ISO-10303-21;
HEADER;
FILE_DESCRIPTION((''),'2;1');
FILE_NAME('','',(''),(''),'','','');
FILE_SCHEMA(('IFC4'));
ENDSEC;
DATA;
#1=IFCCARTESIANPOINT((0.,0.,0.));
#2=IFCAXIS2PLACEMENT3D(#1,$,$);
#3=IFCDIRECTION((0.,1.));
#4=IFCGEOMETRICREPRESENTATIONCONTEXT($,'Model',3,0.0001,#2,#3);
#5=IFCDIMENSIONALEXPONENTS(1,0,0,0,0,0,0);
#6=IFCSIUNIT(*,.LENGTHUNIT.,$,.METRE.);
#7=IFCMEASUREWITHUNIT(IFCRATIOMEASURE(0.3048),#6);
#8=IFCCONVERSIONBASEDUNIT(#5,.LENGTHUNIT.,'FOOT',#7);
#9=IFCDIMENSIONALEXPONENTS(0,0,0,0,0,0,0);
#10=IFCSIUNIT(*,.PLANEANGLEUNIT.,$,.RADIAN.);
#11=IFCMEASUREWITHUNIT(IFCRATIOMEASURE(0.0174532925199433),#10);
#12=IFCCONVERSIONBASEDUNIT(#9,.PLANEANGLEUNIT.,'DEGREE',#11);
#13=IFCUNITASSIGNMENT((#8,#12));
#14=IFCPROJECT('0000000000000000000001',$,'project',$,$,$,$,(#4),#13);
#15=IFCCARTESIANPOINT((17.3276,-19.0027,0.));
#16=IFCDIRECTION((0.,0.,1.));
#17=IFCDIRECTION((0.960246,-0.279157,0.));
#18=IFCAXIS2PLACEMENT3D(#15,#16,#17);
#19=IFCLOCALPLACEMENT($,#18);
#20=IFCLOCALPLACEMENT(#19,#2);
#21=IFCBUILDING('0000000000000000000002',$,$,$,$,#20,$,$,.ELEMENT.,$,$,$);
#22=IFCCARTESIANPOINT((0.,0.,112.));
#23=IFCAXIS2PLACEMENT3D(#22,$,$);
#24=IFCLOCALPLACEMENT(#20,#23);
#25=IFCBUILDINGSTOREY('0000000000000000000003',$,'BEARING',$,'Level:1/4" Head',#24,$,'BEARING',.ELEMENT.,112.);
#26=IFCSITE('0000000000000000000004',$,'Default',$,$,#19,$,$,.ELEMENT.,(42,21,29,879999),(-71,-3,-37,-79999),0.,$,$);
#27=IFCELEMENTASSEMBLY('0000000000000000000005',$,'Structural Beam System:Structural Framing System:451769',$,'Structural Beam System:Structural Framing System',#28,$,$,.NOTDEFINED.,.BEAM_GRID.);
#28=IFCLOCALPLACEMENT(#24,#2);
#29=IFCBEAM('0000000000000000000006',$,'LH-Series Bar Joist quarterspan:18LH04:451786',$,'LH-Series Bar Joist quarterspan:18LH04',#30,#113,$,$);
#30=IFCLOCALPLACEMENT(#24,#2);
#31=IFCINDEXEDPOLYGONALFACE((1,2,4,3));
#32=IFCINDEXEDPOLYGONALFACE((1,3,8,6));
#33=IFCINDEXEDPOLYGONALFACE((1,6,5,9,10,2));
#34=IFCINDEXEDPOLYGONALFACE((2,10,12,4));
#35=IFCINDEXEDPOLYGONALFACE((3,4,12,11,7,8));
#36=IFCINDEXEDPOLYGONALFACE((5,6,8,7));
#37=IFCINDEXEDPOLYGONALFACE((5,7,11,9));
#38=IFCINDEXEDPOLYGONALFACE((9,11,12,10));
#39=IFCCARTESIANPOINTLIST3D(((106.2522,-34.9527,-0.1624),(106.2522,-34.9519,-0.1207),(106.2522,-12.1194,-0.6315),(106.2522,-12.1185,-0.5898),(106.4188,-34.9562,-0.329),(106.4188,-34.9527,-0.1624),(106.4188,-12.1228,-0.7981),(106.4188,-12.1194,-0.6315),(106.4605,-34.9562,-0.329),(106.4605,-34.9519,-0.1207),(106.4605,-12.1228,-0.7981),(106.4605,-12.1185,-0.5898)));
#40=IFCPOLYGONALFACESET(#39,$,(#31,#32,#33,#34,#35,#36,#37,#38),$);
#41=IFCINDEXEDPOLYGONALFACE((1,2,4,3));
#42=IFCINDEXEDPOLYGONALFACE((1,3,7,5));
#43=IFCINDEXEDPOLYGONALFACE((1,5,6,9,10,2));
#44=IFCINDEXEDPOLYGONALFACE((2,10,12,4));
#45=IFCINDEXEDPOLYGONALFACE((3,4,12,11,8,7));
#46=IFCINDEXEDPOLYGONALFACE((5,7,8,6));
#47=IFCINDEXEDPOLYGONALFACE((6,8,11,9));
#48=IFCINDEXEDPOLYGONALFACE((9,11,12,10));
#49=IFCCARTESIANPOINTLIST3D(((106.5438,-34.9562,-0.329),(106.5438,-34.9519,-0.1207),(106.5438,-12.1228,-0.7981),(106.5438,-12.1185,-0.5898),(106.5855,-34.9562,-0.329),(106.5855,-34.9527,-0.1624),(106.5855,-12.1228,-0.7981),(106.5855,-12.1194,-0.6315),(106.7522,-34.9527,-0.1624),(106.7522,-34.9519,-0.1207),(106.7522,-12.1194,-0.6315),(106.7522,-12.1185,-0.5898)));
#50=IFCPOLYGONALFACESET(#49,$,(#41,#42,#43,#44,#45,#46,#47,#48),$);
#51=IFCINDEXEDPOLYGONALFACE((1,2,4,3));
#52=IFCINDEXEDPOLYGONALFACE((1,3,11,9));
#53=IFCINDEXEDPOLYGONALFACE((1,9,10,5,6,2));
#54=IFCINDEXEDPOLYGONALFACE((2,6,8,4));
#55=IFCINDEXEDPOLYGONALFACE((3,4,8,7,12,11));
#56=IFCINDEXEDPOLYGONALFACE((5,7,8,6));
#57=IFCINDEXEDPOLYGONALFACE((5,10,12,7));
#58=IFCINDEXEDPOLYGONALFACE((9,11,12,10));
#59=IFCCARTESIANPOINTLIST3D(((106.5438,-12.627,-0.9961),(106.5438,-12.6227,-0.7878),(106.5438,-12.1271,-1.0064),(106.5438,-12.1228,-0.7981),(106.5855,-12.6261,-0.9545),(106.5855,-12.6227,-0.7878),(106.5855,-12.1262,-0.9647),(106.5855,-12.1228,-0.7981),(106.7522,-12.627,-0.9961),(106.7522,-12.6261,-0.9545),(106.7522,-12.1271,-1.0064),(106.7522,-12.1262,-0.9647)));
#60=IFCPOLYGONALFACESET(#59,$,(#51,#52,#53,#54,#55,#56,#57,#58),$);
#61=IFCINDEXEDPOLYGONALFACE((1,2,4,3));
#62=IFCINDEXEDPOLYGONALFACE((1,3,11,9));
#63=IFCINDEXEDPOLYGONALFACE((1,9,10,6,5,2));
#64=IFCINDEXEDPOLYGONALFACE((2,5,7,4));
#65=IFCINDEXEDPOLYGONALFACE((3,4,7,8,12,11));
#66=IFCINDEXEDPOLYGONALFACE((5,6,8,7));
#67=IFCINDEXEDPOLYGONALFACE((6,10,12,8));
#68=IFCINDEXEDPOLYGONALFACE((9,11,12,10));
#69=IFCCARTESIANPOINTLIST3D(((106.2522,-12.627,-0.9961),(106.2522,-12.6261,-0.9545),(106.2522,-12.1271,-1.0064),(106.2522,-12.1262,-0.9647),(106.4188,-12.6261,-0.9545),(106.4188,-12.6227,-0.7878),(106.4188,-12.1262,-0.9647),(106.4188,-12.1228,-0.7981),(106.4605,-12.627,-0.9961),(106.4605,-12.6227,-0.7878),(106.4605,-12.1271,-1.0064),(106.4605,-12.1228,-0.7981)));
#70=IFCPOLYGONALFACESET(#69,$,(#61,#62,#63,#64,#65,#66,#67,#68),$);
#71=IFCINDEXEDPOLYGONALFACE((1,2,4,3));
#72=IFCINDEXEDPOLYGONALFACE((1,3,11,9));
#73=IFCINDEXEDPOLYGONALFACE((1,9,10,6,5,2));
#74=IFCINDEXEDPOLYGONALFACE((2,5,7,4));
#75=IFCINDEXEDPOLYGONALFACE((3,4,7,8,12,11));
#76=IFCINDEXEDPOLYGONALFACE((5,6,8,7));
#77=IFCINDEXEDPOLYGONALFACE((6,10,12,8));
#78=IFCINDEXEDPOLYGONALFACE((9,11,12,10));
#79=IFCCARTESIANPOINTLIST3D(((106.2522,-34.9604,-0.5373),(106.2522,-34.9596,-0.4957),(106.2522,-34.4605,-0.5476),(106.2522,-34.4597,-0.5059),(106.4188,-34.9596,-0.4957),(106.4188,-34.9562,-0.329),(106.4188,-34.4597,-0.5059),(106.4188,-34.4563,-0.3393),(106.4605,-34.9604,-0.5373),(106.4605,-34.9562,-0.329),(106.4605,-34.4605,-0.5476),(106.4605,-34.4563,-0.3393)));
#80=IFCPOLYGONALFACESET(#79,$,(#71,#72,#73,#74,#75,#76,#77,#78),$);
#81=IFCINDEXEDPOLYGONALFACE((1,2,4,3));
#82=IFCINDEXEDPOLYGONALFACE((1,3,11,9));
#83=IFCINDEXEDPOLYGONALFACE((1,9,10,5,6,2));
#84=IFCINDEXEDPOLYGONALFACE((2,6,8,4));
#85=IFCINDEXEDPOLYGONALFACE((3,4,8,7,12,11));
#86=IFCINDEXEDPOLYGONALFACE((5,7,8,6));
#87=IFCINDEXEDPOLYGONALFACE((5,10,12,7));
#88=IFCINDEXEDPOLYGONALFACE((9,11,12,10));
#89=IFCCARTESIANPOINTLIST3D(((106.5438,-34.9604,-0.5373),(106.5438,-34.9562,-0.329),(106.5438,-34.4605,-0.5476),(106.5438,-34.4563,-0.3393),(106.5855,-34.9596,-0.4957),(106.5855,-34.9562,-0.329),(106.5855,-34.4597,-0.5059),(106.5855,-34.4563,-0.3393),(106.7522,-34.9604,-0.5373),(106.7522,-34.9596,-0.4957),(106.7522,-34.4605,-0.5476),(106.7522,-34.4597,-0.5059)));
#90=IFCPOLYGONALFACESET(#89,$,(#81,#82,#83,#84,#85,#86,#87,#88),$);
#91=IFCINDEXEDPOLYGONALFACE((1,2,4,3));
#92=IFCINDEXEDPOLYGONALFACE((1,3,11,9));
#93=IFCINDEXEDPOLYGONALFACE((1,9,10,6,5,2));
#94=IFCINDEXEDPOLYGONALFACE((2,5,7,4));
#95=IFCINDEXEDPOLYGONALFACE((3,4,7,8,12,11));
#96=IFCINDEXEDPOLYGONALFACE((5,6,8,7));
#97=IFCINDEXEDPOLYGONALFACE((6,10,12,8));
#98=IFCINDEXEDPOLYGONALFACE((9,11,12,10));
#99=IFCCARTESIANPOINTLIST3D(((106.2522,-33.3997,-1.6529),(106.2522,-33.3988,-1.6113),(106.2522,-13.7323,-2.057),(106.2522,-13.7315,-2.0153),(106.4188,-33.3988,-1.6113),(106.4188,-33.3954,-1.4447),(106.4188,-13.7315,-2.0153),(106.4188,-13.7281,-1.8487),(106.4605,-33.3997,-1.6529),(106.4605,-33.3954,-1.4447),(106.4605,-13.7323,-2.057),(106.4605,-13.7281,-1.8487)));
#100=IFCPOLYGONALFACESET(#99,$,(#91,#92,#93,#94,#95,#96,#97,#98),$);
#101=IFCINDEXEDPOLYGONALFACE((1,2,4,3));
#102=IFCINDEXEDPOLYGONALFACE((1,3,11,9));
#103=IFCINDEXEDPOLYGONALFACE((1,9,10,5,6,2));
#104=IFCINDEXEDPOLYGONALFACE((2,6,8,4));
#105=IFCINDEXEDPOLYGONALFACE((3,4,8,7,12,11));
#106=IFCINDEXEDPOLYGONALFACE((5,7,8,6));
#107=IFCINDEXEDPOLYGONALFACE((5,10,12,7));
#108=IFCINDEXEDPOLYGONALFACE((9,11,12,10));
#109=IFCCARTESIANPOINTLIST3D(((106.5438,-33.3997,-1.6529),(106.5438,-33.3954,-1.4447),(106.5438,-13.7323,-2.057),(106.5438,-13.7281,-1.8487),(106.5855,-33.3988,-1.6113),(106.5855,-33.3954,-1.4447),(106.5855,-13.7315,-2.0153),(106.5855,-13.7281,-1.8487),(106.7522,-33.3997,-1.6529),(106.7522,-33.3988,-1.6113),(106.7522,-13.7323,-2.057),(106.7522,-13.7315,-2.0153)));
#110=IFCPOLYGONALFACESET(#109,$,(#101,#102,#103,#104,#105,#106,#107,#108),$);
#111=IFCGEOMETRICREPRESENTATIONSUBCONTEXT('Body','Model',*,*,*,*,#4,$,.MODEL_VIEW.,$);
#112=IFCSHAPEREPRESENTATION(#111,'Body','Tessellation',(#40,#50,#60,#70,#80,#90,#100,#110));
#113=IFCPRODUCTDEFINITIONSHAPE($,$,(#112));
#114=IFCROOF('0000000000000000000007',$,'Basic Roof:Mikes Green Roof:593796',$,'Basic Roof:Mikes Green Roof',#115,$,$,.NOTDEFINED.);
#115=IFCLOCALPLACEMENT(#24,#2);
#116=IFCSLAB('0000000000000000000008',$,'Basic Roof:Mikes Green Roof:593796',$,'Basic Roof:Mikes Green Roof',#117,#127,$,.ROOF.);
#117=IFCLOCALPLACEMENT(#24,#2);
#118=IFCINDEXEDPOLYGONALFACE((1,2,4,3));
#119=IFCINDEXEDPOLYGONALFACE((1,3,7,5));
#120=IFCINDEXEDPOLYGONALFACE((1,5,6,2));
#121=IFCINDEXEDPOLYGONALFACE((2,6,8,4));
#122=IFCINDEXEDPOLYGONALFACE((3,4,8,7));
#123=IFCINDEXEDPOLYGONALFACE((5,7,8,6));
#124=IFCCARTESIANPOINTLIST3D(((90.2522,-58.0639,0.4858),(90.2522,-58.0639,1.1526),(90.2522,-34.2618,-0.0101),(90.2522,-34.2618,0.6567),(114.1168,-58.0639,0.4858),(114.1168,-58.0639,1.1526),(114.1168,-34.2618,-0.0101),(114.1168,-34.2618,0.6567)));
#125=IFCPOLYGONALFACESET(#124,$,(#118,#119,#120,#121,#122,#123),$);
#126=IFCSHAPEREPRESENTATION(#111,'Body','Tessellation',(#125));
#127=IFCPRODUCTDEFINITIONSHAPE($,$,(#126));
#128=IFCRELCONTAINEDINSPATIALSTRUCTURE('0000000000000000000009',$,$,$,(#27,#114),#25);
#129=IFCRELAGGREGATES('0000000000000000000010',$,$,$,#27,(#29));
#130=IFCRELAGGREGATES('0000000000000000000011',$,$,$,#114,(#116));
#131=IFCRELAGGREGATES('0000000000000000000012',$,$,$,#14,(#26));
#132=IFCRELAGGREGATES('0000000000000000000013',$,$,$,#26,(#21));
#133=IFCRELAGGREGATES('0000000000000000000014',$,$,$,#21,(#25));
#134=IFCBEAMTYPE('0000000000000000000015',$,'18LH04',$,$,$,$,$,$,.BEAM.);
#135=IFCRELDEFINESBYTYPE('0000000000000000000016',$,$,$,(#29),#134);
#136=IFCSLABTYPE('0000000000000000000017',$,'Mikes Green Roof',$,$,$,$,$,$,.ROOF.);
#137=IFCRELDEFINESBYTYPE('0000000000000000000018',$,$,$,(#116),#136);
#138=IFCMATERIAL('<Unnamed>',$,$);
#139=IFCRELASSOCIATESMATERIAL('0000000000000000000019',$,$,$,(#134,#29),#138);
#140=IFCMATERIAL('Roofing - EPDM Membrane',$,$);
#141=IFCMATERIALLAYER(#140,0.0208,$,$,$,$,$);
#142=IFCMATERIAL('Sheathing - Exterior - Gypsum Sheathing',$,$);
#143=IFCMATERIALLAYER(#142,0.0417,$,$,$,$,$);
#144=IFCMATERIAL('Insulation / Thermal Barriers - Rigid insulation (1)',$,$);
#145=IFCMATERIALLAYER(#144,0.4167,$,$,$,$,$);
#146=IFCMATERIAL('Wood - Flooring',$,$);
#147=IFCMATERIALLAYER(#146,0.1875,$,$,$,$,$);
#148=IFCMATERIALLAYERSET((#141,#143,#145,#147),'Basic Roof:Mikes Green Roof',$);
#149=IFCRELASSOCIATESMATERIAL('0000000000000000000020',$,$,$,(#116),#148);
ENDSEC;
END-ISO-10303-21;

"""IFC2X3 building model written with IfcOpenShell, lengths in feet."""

from ifc_helpers import new_model, entity, si_unit, converted_unit, direction, frame, frame_2d, origin, place, context, subcontext, project, spatial, polyline, rectangle, outline, extrude, source, transform, mapped, material, layer, layer_set, type_object, type_shapes, element, aggregate, save


model = new_model("IFC2X3")

# Units and contexts
model_context = context("Model", 3, precision=0.0001, world=origin(), true_north=direction((0.0, 1.0)))
body_context = subcontext(model_context, "Body", "Model", "MODEL_VIEW")
ifc_project = project(units=[converted_unit("LENGTHUNIT", "FOOT", entity("IfcRatioMeasure", 0.3048), si_unit("LENGTHUNIT", "METRE"), dimensions=[1, 0, 0, 0, 0, 0, 0]), converted_unit("PLANEANGLEUNIT", "DEGREE", entity("IfcRatioMeasure", 0.0174532925199433), si_unit("PLANEANGLEUNIT", "RADIAN"), dimensions=[0, 0, 0, 0, 0, 0, 0])], contexts=[model_context])

# Site, building, storey
site_placement = place(None, frame((17.3276, -19.0027, 0.0), z_axis=(0.0, 0.0, 1.0), x_axis=(0.960246, -0.279157, 0.0)))
site = spatial("IfcSite", under=ifc_project, at=site_placement, Name="Default", CompositionType="ELEMENT", RefLatitude=(42, 21, 29, 879999), RefLongitude=(-71, -3, -37, -79999), RefElevation=0.0)
building_placement = place(site_placement, origin())
building = spatial("IfcBuilding", under=site, at=building_placement, CompositionType="ELEMENT")
storey_placement = place(building_placement, frame((0.0, 0.0, 112.0)))
storey = spatial("IfcBuildingStorey", under=building, at=storey_placement, Name="BEARING", ObjectType="Level:1/4\" Head", LongName="BEARING", CompositionType="ELEMENT", Elevation=112.0)

# Element assembly, beam
ifc_material_1 = material(Name="<Unnamed>")
assembly_1_placement = place(storey_placement, origin())
assembly_1 = element("IfcElementAssembly", 1, at=assembly_1_placement, inside=storey, Name="Structural Beam System:Structural Framing System:451769", ObjectType="Structural Beam System:Structural Framing System", AssemblyPlace="NOTDEFINED", PredefinedType="BEAM_GRID")
beam_type_1 = type_object("IfcBeamType", Name="18LH04", PredefinedType="BEAM", material=ifc_material_1)
shared_shape_1 = source(origin(), body_context, "Body", "SweptSolid", [
    extrude(outline(polyline([(-0.0833, -0.125), (-0.0417, -0.125), (-0.0417, 0.0417), (0.125, 0.0417), (0.125, 0.0833), (-0.0833, 0.0833), (-0.0833, -0.125)])), frame((-11.4191, -0.125, 0.6667), z_axis=(1.0, 0.0, 0.0), x_axis=(0.0, 0.0, -1.0)), (0.0, 0.0, 1.0), 22.8382),
    extrude(outline(polyline([(-0.0833, -0.0833), (0.125, -0.0833), (0.125, -0.0417), (-0.0417, -0.0417), (-0.0417, 0.125), (-0.0833, 0.125), (-0.0833, -0.0833)])), frame((-11.4191, 0.125, 0.6667), z_axis=(1.0, 0.0, 0.0), x_axis=(0.0, 0.0, -1.0)), (0.0, 0.0, 1.0), 22.8382),
    extrude(outline(polyline([(-0.125, -0.0833), (0.0833, -0.0833), (0.0833, 0.125), (0.0417, 0.125), (0.0417, -0.0417), (-0.125, -0.0417), (-0.125, -0.0833)])), frame((-11.4191, 0.125, 0.4167), z_axis=(1.0, 0.0, 0.0), x_axis=(0.0, 0.0, -1.0)), (0.0, 0.0, 1.0), 0.5),
    extrude(outline(polyline([(0.0417, -0.125), (0.0833, -0.125), (0.0833, 0.0833), (-0.125, 0.0833), (-0.125, 0.0417), (0.0417, 0.0417), (0.0417, -0.125)])), frame((-11.4191, -0.125, 0.4167), z_axis=(1.0, 0.0, 0.0), x_axis=(0.0, 0.0, -1.0)), (0.0, 0.0, 1.0), 0.5),
    extrude(outline(polyline([(0.0417, -0.125), (0.0833, -0.125), (0.0833, 0.0833), (-0.125, 0.0833), (-0.125, 0.0417), (0.0417, 0.0417), (0.0417, -0.125)])), frame((10.9191, -0.125, 0.4167), z_axis=(1.0, 0.0, 0.0), x_axis=(0.0, 0.0, -1.0)), (0.0, 0.0, 1.0), 0.5),
    extrude(outline(polyline([(-0.125, -0.0833), (0.0833, -0.0833), (0.0833, 0.125), (0.0417, 0.125), (0.0417, -0.0417), (-0.125, -0.0417), (-0.125, -0.0833)])), frame((10.9191, 0.125, 0.4167), z_axis=(1.0, 0.0, 0.0), x_axis=(0.0, 0.0, -1.0)), (0.0, 0.0, 1.0), 0.5),
    extrude(outline(polyline([(0.0417, -0.125), (0.0833, -0.125), (0.0833, 0.0833), (-0.125, 0.0833), (-0.125, 0.0417), (0.0417, 0.0417), (0.0417, -0.125)])), frame((-9.8357, -0.125, -0.6667), z_axis=(1.0, 0.0, 0.0), x_axis=(0.0, 0.0, -1.0)), (0.0, 0.0, 1.0), 19.6715),
    extrude(outline(polyline([(-0.125, -0.0833), (0.0833, -0.0833), (0.0833, 0.125), (0.0417, 0.125), (0.0417, -0.0417), (-0.125, -0.0417), (-0.125, -0.0833)])), frame((-9.8357, 0.125, -0.6667), z_axis=(1.0, 0.0, 0.0), x_axis=(0.0, 0.0, -1.0)), (0.0, 0.0, 1.0), 19.6715),
])
type_shapes(beam_type_1, [shared_shape_1])
beam_1_placement = place(assembly_1_placement, frame((106.5022, -23.5506, -1.1051), z_axis=(0.0, 0.020539, 0.999789), x_axis=(0.0, -0.999789, 0.020539)))
beam_1 = element("IfcBeam", 2, at=beam_1_placement, type_object=beam_type_1, material=ifc_material_1, Name="LH-Series Bar Joist quarterspan:18LH04:451786", ObjectType="LH-Series Bar Joist quarterspan:18LH04", context=body_context, shape_type="MappedRepresentation", body=[
    mapped(shared_shape_1, transform((0.0, 0.0, 0.0), scale=1.0)),
])
aggregate(assembly_1, [beam_1])

# Roof, slab
roof_placement = place(storey_placement, frame((90.2522, -58.0639, -0.0101)))
roof = element("IfcRoof", 3, at=roof_placement, inside=storey, Name="Basic Roof:Mikes Green Roof:593796", ObjectType="Basic Roof:Mikes Green Roof", ShapeType="NOTDEFINED")
ifc_material_2 = material(Name="Roofing - EPDM Membrane")
ifc_layer_1 = layer(ifc_material_2, 0.0208)
ifc_material_3 = material(Name="Sheathing - Exterior - Gypsum Sheathing")
ifc_layer_2 = layer(ifc_material_3, 0.0417)
ifc_material_4 = material(Name="Insulation / Thermal Barriers - Rigid insulation (1)")
ifc_layer_3 = layer(ifc_material_4, 0.4167)
ifc_material_5 = material(Name="Wood - Flooring")
ifc_layer_4 = layer(ifc_material_5, 0.1875)
ifc_layer_set = layer_set([ifc_layer_1, ifc_layer_2, ifc_layer_3, ifc_layer_4], Name="Basic Roof:Mikes Green Roof")
slab_type = type_object("IfcSlabType", Name="Mikes Green Roof", PredefinedType="ROOF")
slab_placement = place(roof_placement, origin())
slab = element("IfcSlab", 4, at=slab_placement, type_object=slab_type, material=ifc_layer_set, Name="Basic Roof:Mikes Green Roof:593796", ObjectType="Basic Roof:Mikes Green Roof", PredefinedType="ROOF", context=body_context, shape_type="SweptSolid", body=[
    extrude(rectangle(XDim=23.8646, YDim=23.8072, at=frame_2d((0.0, 0.0), x_axis=(1.0, 0.0))), frame((11.9323, 11.901, 0.2479), z_axis=(0.0, 0.020829, 0.999783), x_axis=(1.0, 0.0, 0.0)), (0.0, -0.020829, 0.999783), 0.6668),
])
aggregate(roof, [slab])

save(model, "model.ifc")
